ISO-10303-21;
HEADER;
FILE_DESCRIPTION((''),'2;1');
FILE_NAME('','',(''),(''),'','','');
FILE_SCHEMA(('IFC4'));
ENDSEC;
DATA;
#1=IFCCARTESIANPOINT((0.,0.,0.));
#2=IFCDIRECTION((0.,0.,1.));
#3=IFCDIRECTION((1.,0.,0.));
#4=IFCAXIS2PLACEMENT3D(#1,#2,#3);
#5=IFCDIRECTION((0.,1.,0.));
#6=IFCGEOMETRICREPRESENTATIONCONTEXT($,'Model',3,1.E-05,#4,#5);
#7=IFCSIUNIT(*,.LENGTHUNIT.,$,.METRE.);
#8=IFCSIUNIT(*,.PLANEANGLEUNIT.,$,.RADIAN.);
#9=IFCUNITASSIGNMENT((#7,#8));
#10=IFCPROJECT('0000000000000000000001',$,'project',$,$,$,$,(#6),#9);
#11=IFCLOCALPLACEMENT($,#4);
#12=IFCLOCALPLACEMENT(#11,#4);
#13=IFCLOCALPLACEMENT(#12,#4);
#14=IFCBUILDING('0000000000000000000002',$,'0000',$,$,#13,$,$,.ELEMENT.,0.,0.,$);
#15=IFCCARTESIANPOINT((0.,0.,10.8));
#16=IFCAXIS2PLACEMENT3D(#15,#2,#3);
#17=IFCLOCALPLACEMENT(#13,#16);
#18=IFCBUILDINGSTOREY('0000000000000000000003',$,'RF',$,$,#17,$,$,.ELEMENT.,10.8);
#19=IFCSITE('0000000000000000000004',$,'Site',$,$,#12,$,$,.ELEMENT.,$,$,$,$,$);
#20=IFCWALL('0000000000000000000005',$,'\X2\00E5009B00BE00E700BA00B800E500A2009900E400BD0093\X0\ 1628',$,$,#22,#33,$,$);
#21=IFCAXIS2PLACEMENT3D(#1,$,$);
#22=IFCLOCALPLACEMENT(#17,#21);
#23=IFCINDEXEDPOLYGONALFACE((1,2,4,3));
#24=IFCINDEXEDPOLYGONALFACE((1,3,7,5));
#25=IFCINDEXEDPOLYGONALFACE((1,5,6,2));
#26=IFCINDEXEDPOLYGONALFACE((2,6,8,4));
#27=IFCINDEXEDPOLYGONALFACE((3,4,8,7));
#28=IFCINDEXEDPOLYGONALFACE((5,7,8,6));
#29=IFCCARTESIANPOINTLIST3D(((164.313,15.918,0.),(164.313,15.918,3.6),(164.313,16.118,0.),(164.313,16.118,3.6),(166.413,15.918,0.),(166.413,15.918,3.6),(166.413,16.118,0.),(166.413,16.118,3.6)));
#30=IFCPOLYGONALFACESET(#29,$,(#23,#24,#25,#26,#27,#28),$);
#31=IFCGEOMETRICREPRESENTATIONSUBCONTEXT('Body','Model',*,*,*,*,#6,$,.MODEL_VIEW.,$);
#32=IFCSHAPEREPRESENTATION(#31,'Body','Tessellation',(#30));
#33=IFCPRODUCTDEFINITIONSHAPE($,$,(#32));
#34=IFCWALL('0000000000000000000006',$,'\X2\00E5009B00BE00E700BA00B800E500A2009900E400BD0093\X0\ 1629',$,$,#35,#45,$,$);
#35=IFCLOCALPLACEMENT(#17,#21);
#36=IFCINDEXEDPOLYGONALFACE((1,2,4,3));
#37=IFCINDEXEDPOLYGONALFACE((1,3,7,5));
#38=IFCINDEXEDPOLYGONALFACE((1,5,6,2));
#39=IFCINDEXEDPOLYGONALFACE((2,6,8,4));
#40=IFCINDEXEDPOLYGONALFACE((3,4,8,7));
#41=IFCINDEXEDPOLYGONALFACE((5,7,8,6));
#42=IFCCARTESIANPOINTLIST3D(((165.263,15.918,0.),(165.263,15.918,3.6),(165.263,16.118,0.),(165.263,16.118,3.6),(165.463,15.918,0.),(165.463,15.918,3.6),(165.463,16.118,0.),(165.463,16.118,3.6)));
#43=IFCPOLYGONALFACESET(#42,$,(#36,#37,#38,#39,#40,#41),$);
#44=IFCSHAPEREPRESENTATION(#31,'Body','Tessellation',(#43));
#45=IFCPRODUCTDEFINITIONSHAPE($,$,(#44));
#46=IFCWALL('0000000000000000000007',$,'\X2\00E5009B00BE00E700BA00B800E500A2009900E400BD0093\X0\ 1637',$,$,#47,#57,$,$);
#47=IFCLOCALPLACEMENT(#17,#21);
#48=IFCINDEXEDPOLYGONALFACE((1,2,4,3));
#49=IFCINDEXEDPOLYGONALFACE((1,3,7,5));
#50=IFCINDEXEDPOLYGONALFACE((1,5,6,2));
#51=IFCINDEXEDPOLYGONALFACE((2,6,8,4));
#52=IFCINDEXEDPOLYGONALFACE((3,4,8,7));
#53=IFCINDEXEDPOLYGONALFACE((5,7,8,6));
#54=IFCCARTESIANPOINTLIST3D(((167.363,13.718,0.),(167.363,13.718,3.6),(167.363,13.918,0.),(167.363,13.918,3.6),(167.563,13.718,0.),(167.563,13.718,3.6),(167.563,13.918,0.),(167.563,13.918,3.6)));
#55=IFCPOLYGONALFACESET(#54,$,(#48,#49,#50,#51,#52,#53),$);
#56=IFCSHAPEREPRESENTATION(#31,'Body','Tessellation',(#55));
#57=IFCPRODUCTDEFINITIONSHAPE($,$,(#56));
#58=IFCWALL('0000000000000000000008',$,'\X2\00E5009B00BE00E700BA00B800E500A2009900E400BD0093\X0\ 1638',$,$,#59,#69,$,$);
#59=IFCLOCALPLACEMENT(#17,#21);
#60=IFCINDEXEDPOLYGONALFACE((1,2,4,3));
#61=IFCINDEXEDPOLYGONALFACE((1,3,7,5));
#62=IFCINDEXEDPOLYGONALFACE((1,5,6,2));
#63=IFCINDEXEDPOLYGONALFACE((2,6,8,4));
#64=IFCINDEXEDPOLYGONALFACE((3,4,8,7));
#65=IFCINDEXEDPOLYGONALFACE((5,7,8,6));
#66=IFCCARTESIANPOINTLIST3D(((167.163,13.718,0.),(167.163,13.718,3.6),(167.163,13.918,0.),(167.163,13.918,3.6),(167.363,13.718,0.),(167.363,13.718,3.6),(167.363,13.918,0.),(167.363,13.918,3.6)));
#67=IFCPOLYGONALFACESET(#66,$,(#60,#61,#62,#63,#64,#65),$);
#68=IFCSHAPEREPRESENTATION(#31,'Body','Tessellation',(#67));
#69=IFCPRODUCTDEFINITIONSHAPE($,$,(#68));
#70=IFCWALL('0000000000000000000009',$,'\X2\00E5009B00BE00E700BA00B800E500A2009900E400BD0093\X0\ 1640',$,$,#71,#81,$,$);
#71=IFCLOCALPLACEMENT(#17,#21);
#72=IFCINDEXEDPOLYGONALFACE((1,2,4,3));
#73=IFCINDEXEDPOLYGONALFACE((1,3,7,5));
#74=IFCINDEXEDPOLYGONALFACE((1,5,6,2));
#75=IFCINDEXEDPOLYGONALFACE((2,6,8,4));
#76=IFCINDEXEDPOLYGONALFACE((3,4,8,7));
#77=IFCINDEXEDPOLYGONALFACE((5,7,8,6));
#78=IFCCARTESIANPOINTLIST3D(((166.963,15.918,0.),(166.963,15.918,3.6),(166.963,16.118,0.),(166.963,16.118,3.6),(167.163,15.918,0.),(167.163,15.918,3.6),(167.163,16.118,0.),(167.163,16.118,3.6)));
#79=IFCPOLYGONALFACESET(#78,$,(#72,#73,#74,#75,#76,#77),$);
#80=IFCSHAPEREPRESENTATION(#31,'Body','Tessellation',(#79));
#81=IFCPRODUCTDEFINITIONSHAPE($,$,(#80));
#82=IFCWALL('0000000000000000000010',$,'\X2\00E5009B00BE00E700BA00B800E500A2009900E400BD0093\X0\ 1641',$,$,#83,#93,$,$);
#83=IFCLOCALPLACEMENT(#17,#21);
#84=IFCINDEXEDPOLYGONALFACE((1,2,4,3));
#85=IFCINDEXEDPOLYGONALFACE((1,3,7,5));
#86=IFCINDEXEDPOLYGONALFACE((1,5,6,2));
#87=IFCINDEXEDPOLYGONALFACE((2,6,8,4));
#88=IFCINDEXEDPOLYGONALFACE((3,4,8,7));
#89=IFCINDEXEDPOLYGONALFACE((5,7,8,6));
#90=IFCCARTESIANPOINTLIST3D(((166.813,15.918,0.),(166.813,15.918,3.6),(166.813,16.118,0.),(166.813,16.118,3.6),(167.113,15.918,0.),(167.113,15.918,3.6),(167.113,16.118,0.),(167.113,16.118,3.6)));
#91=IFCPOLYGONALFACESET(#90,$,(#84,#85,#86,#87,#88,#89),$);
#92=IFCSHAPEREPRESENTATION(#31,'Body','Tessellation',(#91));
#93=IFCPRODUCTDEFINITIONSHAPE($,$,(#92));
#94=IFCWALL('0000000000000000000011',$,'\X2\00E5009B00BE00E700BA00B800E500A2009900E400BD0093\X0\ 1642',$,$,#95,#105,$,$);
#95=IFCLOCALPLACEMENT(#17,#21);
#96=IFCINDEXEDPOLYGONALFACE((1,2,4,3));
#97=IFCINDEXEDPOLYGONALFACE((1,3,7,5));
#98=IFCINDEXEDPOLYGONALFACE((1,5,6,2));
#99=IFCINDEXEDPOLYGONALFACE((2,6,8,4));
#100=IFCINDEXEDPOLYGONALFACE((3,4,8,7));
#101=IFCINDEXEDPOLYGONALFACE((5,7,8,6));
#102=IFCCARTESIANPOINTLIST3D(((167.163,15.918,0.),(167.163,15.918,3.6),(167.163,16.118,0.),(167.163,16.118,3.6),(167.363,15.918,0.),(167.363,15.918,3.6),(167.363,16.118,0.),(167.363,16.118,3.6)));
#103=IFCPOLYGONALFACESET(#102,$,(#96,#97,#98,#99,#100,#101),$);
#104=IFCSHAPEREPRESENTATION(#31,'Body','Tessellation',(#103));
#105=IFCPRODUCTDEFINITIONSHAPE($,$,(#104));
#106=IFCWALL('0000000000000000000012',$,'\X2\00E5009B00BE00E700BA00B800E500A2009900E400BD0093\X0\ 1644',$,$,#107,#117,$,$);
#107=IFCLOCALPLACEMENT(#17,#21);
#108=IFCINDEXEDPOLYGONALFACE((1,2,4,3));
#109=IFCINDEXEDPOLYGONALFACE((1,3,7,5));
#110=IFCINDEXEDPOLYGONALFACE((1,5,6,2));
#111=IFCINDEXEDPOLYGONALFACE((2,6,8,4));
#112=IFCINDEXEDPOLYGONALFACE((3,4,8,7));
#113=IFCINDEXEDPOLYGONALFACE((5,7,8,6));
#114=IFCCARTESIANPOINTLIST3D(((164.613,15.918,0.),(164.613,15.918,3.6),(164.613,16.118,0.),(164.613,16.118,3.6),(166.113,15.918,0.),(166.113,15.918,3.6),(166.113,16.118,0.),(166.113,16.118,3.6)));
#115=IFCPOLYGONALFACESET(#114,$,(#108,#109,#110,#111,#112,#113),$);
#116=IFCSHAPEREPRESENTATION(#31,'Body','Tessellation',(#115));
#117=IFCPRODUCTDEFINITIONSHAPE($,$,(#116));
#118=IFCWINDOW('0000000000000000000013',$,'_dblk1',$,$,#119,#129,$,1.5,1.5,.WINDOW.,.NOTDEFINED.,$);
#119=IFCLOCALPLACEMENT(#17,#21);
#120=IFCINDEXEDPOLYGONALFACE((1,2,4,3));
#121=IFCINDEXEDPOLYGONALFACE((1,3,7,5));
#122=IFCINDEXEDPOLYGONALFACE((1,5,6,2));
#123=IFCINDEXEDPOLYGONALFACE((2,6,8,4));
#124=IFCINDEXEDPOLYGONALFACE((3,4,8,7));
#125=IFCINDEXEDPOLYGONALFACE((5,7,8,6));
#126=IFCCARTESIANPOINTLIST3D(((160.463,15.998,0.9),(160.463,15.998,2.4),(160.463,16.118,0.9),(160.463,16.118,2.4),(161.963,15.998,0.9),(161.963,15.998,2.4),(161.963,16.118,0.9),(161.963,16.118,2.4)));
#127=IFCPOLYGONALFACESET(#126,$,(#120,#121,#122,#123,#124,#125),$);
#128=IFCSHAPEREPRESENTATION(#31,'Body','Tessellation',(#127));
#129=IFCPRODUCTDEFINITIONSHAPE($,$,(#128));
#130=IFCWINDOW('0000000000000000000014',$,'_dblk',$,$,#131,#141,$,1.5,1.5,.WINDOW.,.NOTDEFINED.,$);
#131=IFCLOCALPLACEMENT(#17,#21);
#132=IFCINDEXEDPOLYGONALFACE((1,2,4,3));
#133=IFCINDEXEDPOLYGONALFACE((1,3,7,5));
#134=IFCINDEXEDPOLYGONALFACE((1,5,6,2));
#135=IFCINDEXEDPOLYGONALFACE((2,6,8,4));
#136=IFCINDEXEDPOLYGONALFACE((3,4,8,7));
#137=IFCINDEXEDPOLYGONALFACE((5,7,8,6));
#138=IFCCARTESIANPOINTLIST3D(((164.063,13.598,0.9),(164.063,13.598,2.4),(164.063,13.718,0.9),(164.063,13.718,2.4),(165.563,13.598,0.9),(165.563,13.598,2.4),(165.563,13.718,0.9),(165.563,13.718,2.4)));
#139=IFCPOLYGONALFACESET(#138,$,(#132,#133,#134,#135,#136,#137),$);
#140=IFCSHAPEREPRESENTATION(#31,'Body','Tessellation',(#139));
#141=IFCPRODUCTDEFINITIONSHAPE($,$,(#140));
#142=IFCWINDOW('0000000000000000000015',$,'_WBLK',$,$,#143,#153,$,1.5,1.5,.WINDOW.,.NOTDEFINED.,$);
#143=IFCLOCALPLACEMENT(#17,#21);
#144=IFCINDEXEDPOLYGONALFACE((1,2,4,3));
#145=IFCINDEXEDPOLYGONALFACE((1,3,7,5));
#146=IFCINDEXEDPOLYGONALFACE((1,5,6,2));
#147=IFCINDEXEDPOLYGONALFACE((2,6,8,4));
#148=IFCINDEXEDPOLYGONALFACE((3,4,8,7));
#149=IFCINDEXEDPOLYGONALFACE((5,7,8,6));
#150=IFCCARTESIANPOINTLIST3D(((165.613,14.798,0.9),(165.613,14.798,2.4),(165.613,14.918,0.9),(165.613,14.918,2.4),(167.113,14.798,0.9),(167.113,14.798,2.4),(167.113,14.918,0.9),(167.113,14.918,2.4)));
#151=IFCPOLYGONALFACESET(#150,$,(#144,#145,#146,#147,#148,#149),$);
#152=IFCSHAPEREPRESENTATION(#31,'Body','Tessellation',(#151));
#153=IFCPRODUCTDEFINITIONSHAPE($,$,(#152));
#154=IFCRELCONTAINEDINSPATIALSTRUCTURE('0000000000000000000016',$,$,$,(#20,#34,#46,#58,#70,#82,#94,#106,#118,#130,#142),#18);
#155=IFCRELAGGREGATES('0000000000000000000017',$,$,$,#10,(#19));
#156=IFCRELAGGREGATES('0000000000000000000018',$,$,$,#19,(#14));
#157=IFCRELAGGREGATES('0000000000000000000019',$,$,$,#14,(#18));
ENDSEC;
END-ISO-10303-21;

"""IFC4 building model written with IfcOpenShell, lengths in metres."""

from ifc_helpers import new_model, si_unit, direction, frame, frame_2d, origin_with_axes, place, context, subcontext, project, spatial, rectangle, extrude, element, save


model = new_model("IFC4")

# Units and contexts
model_context = context("Model", 3, precision=1e-05, world=origin_with_axes(), true_north=direction((0.0, 1.0, 0.0)))
body_context = subcontext(model_context, "Body", "Model", "MODEL_VIEW")
ifc_project = project(units=[si_unit("LENGTHUNIT", "METRE"), si_unit("PLANEANGLEUNIT", "RADIAN")], contexts=[model_context])

# Site, building, storey
placement = place(None, origin_with_axes())
site_placement = place(placement, origin_with_axes())
site = spatial("IfcSite", under=ifc_project, at=site_placement, Name="Site", CompositionType="ELEMENT")
building_placement = place(site_placement, origin_with_axes())
building = spatial("IfcBuilding", under=site, at=building_placement, Name="0000", CompositionType="ELEMENT", ElevationOfRefHeight=0.0, ElevationOfTerrain=0.0)
storey_placement = place(building_placement, frame((0.0, 0.0, 10.8), z_axis=(0.0, 0.0, 1.0), x_axis=(1.0, 0.0, 0.0)))
storey = spatial("IfcBuildingStorey", under=building, at=storey_placement, Name="RF", CompositionType="ELEMENT", Elevation=10.8)

# Walls
wall_1_placement = place(storey_placement, frame((165.363, 16.018, 0.0), z_axis=(0.0, 0.0, 1.0), x_axis=(1.0, 0.0, 0.0)))
element("IfcWall", 1, at=wall_1_placement, inside=storey, Name="å\u009b¾çº¸å¢\u0099ä½\u0093 1628", context=body_context, shape_type="SweptSolid", body=[
    extrude(rectangle(XDim=2.1, YDim=0.2, at=frame_2d((0.0, 0.0), x_axis=(1.0, 0.0, 0.0))), frame((0.0, 0.0, 0.0), z_axis=(0.0, 0.0, 1.0)), (0.0, 0.0, 1.0), 3.6),
])
for number, where, z_axis, x_axis, name in (
    (2, (165.363, 16.018, 0.0), (0.0, 0.0, 1.0), (0.0, 1.0, 0.0), "å\u009b¾çº¸å¢\u0099ä½\u0093 1629"),
    (3, (167.463, 13.818, 0.0), (0.0, 0.0, 1.0), (0.0, -1.0, 0.0), "å\u009b¾çº¸å¢\u0099ä½\u0093 1637"),
    (4, (167.263, 13.818, 0.0), (0.0, 0.0, 1.0), (1.0, 0.0, 0.0), "å\u009b¾çº¸å¢\u0099ä½\u0093 1638"),
    (5, (167.063, 16.018, 0.0), (0.0, 0.0, 1.0), (-1.0, 0.0, 0.0), "å\u009b¾çº¸å¢\u0099ä½\u0093 1640"),
):
    element("IfcWall", number, at=place(storey_placement, frame(where, z_axis=z_axis, x_axis=x_axis)), inside=storey, Name=name, context=body_context, shape_type="SweptSolid", body=[
        extrude(rectangle(XDim=0.2, YDim=0.2, at=frame_2d((0.0, 0.0), x_axis=(1.0, 0.0, 0.0))), frame((0.0, 0.0, 0.0), z_axis=(0.0, 0.0, 1.0)), (0.0, 0.0, 1.0), 3.6),
    ])
wall_2_placement = place(storey_placement, frame((166.963, 16.018, 0.0), z_axis=(0.0, 0.0, 1.0), x_axis=(1.0, 0.0, 0.0)))
element("IfcWall", 6, at=wall_2_placement, inside=storey, Name="å\u009b¾çº¸å¢\u0099ä½\u0093 1641", context=body_context, shape_type="SweptSolid", body=[
    extrude(rectangle(XDim=0.3, YDim=0.2, at=frame_2d((0.0, 0.0), x_axis=(1.0, 0.0, 0.0))), frame((0.0, 0.0, 0.0), z_axis=(0.0, 0.0, 1.0)), (0.0, 0.0, 1.0), 3.6),
])
for number, where, z_axis, x_axis, name in (
    (7, (167.263, 16.018, 0.0), (0.0, 0.0, 1.0), (1.0, 0.0, 0.0), "å\u009b¾çº¸å¢\u0099ä½\u0093 1642"),
):
    element("IfcWall", number, at=place(storey_placement, frame(where, z_axis=z_axis, x_axis=x_axis)), inside=storey, Name=name, context=body_context, shape_type="SweptSolid", body=[
        extrude(rectangle(XDim=0.2, YDim=0.2, at=frame_2d((0.0, 0.0), x_axis=(1.0, 0.0, 0.0))), frame((0.0, 0.0, 0.0), z_axis=(0.0, 0.0, 1.0)), (0.0, 0.0, 1.0), 3.6),
    ])
wall_3_placement = place(storey_placement, frame((165.363, 16.018, 0.0), z_axis=(0.0, 0.0, 1.0), x_axis=(-1.0, 0.0, 0.0)))
element("IfcWall", 8, at=wall_3_placement, inside=storey, Name="å\u009b¾çº¸å¢\u0099ä½\u0093 1644", context=body_context, shape_type="SweptSolid", body=[
    extrude(rectangle(XDim=1.5, YDim=0.2, at=frame_2d((0.0, 0.0), x_axis=(1.0, 0.0, 0.0))), frame((0.0, 0.0, 0.0), z_axis=(0.0, 0.0, 1.0)), (0.0, 0.0, 1.0), 3.6),
])

# Windows
for number, where, z_axis, x_axis, name in (
    (9, (161.213, 16.058, 0.9), (0.0, 0.0, 1.0), (1.0, 0.0, 0.0), "_dblk1"),
    (10, (164.813, 13.658, 0.9), (0.0, 0.0, 1.0), (1.0, 0.0, 0.0), "_dblk"),
    (11, (166.363, 14.858, 0.9), (0.0, 0.0, 1.0), (1.0, 0.0, 0.0), "_WBLK"),
):
    element("IfcWindow", number, at=place(storey_placement, frame(where, z_axis=z_axis, x_axis=x_axis)), inside=storey, Name=name, OverallHeight=1.5, OverallWidth=1.5, PartitioningType="NOTDEFINED", PredefinedType="WINDOW", context=body_context, shape_type="SweptSolid", body=[
        extrude(rectangle(XDim=1.5, YDim=0.12, at=frame_2d((0.0, 0.0), x_axis=(1.0, 0.0, 0.0))), frame((0.0, 0.0, 0.0), z_axis=(0.0, 0.0, 1.0)), (0.0, 0.0, 1.0), 1.5),
    ])

save(model, "model.ifc")
